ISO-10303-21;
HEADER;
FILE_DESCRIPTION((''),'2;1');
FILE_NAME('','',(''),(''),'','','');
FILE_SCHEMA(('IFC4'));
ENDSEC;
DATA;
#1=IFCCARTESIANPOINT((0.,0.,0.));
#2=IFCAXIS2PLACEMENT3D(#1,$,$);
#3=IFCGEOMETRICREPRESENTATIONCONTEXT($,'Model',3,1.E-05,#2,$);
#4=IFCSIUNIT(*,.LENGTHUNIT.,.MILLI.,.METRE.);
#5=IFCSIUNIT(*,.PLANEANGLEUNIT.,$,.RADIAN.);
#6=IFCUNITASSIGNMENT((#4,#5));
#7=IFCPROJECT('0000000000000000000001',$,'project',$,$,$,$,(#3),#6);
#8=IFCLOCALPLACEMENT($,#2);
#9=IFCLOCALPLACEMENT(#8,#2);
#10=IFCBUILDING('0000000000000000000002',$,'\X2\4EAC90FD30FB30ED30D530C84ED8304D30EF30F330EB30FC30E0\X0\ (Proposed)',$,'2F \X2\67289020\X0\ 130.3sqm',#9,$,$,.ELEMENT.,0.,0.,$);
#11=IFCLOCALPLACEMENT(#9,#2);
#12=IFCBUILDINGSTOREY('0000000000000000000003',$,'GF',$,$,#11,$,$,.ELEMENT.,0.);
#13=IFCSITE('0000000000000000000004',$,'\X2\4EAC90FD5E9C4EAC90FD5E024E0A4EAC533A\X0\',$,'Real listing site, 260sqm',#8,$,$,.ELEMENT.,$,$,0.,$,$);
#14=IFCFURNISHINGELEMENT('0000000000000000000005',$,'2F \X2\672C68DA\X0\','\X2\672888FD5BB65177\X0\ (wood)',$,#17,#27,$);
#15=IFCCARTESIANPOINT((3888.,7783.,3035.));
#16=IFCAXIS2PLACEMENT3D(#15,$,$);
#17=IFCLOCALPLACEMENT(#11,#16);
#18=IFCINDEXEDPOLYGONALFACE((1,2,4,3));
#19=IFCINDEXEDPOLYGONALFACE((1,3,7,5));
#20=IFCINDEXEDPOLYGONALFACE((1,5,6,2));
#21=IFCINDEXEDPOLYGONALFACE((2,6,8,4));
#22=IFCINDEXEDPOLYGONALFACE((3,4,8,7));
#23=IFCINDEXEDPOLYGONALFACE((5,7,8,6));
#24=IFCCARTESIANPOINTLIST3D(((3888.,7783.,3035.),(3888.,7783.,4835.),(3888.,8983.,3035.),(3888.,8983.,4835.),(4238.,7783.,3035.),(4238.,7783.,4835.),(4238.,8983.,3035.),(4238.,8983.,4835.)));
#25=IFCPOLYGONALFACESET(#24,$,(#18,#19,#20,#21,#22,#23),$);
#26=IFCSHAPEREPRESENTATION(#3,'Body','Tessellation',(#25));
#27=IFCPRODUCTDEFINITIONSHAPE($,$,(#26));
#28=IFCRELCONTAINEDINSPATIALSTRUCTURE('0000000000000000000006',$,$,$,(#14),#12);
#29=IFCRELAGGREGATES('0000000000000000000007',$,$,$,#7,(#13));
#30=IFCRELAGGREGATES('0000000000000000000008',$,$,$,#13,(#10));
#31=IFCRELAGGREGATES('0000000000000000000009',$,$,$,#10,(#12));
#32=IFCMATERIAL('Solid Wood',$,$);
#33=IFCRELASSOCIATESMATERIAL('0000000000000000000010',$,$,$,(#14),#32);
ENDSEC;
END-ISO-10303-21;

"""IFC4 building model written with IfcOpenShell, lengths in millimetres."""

from ifc_helpers import new_model, si_unit, frame, frame_2d, origin, place, context, project, spatial, rectangle, extrude, material, element, save


model = new_model("IFC4")

# Units and contexts
model_context = context("Model", 3, precision=1e-05, world=origin())
ifc_project = project(units=[si_unit("LENGTHUNIT", "METRE", prefix="MILLI"), si_unit("PLANEANGLEUNIT", "RADIAN")], contexts=[model_context])

# Site, building, storey
site_placement = place(None, origin())
site = spatial("IfcSite", under=ifc_project, at=site_placement, Name="京都府京都市上京区", ObjectType="Real listing site, 260sqm", CompositionType="ELEMENT", RefElevation=0.0)
building_placement = place(site_placement, origin())
building = spatial("IfcBuilding", under=site, at=building_placement, Name="京都・ロフト付きワンルーム (Proposed)", ObjectType="2F 木造 130.3sqm", CompositionType="ELEMENT", ElevationOfRefHeight=0.0, ElevationOfTerrain=0.0)
storey_placement = place(building_placement, origin())
storey = spatial("IfcBuildingStorey", under=building, at=storey_placement, Name="GF", CompositionType="ELEMENT", Elevation=0.0)

# Shared definitions
ifc_material_1 = material(Name="Solid Wood")

# Furnishing element
furnishing_placement = place(storey_placement, frame((3888.0, 7783.0, 3035.0)))
element("IfcFurnishingElement", 1, at=furnishing_placement, inside=storey, material=ifc_material_1, Name="2F 本棚", Description="木製家具 (wood)", context=model_context, shape_type="SweptSolid", body=[
    extrude(rectangle(XDim=350.0, YDim=1200.0, at=frame_2d((175.0, 600.0))), frame((3888.0, 7783.0, 3035.0)), (0.0, 0.0, 1.0), 1800.0),
])

save(model, "model.ifc")
